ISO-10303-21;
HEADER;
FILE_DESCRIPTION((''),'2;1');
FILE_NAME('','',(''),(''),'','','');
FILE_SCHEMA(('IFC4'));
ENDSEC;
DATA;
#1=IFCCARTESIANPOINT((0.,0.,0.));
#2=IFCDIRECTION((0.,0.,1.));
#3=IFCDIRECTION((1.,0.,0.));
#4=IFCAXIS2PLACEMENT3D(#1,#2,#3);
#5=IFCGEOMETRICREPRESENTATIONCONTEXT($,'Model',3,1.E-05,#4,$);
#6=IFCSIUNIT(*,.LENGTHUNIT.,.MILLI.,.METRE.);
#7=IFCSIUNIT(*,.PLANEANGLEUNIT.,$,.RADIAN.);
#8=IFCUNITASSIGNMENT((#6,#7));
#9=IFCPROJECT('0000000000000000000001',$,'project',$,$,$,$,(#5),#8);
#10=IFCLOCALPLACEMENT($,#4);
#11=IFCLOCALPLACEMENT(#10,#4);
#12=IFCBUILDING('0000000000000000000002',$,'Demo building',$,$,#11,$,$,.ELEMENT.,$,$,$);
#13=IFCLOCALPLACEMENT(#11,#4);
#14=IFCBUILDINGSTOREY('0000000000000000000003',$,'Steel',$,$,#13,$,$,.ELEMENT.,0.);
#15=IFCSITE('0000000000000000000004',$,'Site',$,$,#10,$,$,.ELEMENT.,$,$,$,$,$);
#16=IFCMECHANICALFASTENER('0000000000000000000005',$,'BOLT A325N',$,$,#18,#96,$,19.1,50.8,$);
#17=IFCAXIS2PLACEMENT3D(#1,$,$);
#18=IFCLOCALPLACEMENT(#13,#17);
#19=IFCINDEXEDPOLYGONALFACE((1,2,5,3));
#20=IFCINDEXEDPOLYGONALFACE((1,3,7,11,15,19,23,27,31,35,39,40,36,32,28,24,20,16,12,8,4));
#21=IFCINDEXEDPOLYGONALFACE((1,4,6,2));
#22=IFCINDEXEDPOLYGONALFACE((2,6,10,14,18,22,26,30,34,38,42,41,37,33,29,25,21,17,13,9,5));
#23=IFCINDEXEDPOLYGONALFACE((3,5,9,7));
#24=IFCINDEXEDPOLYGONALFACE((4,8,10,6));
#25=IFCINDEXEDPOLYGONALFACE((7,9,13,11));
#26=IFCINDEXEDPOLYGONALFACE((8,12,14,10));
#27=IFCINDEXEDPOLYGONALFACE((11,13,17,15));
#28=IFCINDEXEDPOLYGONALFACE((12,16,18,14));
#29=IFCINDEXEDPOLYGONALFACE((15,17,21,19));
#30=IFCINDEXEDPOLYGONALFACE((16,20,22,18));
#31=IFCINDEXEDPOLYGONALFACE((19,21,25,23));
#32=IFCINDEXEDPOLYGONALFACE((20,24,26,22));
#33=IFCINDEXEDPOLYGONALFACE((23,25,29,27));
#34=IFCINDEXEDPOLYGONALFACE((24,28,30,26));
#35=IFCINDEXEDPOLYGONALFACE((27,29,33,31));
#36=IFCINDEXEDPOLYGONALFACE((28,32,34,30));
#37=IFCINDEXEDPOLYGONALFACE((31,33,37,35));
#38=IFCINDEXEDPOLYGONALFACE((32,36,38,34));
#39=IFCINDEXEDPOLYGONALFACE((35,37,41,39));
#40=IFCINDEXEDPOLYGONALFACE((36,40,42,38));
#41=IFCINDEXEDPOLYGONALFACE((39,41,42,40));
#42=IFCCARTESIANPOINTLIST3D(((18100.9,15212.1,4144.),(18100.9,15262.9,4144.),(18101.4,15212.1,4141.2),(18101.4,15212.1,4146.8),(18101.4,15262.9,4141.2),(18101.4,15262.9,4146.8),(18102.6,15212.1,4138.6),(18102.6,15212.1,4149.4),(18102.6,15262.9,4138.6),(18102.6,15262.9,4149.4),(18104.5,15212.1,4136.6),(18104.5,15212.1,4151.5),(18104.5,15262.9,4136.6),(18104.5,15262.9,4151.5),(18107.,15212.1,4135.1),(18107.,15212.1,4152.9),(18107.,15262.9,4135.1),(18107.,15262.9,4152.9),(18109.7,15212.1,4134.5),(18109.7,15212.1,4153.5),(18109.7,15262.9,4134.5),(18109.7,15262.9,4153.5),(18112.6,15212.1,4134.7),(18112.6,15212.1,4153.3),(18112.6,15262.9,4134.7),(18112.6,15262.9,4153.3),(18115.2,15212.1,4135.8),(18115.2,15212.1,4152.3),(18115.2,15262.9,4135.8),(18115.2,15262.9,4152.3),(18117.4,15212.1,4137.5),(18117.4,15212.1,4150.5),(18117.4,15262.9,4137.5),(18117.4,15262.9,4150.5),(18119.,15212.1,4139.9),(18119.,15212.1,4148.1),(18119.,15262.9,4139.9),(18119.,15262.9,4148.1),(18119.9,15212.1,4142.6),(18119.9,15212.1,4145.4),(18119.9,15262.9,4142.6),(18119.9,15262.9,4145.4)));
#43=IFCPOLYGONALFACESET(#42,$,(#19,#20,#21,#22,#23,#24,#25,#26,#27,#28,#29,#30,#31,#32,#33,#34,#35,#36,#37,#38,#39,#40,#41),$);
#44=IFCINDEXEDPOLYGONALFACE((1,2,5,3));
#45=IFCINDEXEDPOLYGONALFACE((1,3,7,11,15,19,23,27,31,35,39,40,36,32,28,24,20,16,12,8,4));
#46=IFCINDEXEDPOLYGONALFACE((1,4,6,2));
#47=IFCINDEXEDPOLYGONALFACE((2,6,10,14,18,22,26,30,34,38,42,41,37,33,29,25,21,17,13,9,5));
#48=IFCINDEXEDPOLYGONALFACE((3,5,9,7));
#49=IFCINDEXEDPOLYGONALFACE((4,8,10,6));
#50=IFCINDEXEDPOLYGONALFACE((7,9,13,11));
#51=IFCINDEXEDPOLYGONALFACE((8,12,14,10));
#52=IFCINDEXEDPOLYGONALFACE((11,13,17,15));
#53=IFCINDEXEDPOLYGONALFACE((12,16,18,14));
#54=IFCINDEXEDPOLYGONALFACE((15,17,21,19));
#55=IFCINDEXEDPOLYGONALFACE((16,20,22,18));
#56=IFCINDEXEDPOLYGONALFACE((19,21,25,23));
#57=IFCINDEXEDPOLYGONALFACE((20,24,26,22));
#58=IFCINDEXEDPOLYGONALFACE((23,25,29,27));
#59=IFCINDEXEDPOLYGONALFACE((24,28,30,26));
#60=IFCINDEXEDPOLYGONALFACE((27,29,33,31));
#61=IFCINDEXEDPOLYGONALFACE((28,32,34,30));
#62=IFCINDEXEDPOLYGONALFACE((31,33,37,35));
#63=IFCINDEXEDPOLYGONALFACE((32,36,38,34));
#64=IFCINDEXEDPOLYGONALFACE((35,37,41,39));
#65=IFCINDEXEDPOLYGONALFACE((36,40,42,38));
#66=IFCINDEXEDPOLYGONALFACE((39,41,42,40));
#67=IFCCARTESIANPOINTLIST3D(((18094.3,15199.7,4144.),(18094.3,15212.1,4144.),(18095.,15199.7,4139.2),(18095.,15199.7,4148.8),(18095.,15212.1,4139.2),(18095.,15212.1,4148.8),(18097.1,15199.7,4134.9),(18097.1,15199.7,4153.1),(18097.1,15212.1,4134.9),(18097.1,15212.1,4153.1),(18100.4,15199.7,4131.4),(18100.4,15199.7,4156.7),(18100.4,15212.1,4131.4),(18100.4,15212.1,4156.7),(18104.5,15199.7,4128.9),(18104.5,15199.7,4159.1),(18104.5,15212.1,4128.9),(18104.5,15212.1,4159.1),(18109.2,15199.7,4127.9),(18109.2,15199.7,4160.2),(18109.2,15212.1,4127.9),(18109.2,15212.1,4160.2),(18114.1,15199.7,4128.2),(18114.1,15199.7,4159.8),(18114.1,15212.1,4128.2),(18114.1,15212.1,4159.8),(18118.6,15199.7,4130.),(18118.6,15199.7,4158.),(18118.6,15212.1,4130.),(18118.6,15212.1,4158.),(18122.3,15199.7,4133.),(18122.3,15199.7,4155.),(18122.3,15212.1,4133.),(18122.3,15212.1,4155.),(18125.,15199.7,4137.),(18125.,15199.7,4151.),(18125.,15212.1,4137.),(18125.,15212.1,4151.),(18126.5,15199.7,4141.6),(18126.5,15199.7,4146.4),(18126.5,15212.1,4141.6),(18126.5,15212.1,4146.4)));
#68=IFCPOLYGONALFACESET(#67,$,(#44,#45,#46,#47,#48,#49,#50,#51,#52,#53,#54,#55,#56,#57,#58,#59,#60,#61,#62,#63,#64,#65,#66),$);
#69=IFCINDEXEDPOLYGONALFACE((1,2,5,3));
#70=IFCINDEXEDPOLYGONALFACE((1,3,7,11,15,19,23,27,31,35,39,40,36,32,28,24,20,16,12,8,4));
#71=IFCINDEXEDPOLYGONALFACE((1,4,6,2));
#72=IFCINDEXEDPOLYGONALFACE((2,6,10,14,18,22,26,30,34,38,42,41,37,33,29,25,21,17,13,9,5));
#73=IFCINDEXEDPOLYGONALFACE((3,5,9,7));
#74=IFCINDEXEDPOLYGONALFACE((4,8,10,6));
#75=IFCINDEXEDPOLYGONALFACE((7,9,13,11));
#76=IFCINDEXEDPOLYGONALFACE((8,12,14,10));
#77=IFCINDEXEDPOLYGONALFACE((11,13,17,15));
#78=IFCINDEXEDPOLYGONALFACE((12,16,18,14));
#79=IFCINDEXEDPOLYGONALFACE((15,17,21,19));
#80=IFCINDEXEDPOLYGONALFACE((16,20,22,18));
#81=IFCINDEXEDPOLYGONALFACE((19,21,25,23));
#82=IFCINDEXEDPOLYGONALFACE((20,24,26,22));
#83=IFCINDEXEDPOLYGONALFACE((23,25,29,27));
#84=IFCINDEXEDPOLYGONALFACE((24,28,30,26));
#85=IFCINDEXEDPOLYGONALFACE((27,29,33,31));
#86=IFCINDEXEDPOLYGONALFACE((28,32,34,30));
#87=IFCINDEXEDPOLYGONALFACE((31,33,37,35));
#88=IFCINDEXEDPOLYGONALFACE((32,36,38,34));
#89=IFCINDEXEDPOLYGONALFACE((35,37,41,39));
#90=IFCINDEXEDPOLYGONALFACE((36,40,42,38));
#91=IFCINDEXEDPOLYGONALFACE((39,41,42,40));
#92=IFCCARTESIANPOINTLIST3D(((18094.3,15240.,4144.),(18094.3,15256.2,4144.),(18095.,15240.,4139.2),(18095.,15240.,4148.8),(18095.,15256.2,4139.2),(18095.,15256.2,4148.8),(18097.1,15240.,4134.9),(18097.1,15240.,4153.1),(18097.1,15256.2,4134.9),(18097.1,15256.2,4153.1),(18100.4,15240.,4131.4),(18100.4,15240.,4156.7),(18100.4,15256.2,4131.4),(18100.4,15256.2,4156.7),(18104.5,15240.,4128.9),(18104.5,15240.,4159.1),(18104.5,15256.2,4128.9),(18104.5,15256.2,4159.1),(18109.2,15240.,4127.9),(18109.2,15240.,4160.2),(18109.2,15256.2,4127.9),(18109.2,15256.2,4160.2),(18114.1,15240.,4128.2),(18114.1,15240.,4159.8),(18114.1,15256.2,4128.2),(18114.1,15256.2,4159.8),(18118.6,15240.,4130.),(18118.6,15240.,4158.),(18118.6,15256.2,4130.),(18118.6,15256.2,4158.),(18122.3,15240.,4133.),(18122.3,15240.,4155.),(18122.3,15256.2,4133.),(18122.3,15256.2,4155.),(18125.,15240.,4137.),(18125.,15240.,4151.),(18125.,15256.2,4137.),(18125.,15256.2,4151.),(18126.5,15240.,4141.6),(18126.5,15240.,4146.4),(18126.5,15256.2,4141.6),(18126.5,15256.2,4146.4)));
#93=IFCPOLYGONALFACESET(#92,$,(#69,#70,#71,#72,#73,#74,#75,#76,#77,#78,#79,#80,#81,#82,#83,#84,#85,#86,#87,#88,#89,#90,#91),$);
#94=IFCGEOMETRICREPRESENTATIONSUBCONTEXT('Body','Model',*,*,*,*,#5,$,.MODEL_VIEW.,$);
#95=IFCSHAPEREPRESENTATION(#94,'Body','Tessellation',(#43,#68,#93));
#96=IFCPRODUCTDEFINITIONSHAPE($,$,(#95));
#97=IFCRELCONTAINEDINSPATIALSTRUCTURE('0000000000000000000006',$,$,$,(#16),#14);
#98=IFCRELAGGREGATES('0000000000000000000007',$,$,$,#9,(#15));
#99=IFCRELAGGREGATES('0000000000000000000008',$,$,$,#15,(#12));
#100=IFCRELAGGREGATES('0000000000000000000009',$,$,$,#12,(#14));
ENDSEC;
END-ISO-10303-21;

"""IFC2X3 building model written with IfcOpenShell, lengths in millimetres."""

from ifc_helpers import new_model, si_unit, frame, origin, origin_with_axes, origin_2d, place, context, subcontext, project, spatial, circle, extrude, element, save


model = new_model("IFC2X3")

# Units and contexts
model_context = context("Model", 3, precision=1e-05, world=origin_with_axes())
body_context = subcontext(model_context, "Body", "Model", "MODEL_VIEW")
ifc_project = project(units=[si_unit("LENGTHUNIT", "METRE", prefix="MILLI"), si_unit("PLANEANGLEUNIT", "RADIAN")], contexts=[model_context])

# Site, building, storey
site_placement = place(None, origin_with_axes())
site = spatial("IfcSite", under=ifc_project, at=site_placement, Name="Site", CompositionType="ELEMENT")
building_placement = place(site_placement, origin_with_axes())
building = spatial("IfcBuilding", under=site, at=building_placement, Name="Demo building", CompositionType="ELEMENT")
placement = place(building_placement, origin_with_axes())
storey = spatial("IfcBuildingStorey", under=building, at=placement, Name="Steel", CompositionType="ELEMENT", Elevation=0.0)

# Mechanical fastener
for number, where, z_axis, x_axis, name in (
    (1, (18110.5, 15212.1, 4144.0), (0.0, 1.0, 0.0), (-1.0, 0.0, 0.0), "BOLT A325N"),
):
    element("IfcMechanicalFastener", number, at=place(placement, frame(where, z_axis=z_axis, x_axis=x_axis)), inside=storey, Name=name, NominalDiameter=19.1, NominalLength=50.8, context=body_context, shape_type="SweptSolid", body=[
        extrude(circle(Radius=9.5, at=origin_2d()), origin(), (0.0, 0.0, 1.0), 50.8),
        extrude(circle(Radius=16.2, at=origin_2d()), frame((0.0, 0.0, -12.4)), (0.0, 0.0, 1.0), 12.4),
        extrude(circle(Radius=16.2, at=origin_2d()), frame((0.0, 0.0, 27.9)), (0.0, 0.0, 1.0), 16.2),
    ])

save(model, "model.ifc")
